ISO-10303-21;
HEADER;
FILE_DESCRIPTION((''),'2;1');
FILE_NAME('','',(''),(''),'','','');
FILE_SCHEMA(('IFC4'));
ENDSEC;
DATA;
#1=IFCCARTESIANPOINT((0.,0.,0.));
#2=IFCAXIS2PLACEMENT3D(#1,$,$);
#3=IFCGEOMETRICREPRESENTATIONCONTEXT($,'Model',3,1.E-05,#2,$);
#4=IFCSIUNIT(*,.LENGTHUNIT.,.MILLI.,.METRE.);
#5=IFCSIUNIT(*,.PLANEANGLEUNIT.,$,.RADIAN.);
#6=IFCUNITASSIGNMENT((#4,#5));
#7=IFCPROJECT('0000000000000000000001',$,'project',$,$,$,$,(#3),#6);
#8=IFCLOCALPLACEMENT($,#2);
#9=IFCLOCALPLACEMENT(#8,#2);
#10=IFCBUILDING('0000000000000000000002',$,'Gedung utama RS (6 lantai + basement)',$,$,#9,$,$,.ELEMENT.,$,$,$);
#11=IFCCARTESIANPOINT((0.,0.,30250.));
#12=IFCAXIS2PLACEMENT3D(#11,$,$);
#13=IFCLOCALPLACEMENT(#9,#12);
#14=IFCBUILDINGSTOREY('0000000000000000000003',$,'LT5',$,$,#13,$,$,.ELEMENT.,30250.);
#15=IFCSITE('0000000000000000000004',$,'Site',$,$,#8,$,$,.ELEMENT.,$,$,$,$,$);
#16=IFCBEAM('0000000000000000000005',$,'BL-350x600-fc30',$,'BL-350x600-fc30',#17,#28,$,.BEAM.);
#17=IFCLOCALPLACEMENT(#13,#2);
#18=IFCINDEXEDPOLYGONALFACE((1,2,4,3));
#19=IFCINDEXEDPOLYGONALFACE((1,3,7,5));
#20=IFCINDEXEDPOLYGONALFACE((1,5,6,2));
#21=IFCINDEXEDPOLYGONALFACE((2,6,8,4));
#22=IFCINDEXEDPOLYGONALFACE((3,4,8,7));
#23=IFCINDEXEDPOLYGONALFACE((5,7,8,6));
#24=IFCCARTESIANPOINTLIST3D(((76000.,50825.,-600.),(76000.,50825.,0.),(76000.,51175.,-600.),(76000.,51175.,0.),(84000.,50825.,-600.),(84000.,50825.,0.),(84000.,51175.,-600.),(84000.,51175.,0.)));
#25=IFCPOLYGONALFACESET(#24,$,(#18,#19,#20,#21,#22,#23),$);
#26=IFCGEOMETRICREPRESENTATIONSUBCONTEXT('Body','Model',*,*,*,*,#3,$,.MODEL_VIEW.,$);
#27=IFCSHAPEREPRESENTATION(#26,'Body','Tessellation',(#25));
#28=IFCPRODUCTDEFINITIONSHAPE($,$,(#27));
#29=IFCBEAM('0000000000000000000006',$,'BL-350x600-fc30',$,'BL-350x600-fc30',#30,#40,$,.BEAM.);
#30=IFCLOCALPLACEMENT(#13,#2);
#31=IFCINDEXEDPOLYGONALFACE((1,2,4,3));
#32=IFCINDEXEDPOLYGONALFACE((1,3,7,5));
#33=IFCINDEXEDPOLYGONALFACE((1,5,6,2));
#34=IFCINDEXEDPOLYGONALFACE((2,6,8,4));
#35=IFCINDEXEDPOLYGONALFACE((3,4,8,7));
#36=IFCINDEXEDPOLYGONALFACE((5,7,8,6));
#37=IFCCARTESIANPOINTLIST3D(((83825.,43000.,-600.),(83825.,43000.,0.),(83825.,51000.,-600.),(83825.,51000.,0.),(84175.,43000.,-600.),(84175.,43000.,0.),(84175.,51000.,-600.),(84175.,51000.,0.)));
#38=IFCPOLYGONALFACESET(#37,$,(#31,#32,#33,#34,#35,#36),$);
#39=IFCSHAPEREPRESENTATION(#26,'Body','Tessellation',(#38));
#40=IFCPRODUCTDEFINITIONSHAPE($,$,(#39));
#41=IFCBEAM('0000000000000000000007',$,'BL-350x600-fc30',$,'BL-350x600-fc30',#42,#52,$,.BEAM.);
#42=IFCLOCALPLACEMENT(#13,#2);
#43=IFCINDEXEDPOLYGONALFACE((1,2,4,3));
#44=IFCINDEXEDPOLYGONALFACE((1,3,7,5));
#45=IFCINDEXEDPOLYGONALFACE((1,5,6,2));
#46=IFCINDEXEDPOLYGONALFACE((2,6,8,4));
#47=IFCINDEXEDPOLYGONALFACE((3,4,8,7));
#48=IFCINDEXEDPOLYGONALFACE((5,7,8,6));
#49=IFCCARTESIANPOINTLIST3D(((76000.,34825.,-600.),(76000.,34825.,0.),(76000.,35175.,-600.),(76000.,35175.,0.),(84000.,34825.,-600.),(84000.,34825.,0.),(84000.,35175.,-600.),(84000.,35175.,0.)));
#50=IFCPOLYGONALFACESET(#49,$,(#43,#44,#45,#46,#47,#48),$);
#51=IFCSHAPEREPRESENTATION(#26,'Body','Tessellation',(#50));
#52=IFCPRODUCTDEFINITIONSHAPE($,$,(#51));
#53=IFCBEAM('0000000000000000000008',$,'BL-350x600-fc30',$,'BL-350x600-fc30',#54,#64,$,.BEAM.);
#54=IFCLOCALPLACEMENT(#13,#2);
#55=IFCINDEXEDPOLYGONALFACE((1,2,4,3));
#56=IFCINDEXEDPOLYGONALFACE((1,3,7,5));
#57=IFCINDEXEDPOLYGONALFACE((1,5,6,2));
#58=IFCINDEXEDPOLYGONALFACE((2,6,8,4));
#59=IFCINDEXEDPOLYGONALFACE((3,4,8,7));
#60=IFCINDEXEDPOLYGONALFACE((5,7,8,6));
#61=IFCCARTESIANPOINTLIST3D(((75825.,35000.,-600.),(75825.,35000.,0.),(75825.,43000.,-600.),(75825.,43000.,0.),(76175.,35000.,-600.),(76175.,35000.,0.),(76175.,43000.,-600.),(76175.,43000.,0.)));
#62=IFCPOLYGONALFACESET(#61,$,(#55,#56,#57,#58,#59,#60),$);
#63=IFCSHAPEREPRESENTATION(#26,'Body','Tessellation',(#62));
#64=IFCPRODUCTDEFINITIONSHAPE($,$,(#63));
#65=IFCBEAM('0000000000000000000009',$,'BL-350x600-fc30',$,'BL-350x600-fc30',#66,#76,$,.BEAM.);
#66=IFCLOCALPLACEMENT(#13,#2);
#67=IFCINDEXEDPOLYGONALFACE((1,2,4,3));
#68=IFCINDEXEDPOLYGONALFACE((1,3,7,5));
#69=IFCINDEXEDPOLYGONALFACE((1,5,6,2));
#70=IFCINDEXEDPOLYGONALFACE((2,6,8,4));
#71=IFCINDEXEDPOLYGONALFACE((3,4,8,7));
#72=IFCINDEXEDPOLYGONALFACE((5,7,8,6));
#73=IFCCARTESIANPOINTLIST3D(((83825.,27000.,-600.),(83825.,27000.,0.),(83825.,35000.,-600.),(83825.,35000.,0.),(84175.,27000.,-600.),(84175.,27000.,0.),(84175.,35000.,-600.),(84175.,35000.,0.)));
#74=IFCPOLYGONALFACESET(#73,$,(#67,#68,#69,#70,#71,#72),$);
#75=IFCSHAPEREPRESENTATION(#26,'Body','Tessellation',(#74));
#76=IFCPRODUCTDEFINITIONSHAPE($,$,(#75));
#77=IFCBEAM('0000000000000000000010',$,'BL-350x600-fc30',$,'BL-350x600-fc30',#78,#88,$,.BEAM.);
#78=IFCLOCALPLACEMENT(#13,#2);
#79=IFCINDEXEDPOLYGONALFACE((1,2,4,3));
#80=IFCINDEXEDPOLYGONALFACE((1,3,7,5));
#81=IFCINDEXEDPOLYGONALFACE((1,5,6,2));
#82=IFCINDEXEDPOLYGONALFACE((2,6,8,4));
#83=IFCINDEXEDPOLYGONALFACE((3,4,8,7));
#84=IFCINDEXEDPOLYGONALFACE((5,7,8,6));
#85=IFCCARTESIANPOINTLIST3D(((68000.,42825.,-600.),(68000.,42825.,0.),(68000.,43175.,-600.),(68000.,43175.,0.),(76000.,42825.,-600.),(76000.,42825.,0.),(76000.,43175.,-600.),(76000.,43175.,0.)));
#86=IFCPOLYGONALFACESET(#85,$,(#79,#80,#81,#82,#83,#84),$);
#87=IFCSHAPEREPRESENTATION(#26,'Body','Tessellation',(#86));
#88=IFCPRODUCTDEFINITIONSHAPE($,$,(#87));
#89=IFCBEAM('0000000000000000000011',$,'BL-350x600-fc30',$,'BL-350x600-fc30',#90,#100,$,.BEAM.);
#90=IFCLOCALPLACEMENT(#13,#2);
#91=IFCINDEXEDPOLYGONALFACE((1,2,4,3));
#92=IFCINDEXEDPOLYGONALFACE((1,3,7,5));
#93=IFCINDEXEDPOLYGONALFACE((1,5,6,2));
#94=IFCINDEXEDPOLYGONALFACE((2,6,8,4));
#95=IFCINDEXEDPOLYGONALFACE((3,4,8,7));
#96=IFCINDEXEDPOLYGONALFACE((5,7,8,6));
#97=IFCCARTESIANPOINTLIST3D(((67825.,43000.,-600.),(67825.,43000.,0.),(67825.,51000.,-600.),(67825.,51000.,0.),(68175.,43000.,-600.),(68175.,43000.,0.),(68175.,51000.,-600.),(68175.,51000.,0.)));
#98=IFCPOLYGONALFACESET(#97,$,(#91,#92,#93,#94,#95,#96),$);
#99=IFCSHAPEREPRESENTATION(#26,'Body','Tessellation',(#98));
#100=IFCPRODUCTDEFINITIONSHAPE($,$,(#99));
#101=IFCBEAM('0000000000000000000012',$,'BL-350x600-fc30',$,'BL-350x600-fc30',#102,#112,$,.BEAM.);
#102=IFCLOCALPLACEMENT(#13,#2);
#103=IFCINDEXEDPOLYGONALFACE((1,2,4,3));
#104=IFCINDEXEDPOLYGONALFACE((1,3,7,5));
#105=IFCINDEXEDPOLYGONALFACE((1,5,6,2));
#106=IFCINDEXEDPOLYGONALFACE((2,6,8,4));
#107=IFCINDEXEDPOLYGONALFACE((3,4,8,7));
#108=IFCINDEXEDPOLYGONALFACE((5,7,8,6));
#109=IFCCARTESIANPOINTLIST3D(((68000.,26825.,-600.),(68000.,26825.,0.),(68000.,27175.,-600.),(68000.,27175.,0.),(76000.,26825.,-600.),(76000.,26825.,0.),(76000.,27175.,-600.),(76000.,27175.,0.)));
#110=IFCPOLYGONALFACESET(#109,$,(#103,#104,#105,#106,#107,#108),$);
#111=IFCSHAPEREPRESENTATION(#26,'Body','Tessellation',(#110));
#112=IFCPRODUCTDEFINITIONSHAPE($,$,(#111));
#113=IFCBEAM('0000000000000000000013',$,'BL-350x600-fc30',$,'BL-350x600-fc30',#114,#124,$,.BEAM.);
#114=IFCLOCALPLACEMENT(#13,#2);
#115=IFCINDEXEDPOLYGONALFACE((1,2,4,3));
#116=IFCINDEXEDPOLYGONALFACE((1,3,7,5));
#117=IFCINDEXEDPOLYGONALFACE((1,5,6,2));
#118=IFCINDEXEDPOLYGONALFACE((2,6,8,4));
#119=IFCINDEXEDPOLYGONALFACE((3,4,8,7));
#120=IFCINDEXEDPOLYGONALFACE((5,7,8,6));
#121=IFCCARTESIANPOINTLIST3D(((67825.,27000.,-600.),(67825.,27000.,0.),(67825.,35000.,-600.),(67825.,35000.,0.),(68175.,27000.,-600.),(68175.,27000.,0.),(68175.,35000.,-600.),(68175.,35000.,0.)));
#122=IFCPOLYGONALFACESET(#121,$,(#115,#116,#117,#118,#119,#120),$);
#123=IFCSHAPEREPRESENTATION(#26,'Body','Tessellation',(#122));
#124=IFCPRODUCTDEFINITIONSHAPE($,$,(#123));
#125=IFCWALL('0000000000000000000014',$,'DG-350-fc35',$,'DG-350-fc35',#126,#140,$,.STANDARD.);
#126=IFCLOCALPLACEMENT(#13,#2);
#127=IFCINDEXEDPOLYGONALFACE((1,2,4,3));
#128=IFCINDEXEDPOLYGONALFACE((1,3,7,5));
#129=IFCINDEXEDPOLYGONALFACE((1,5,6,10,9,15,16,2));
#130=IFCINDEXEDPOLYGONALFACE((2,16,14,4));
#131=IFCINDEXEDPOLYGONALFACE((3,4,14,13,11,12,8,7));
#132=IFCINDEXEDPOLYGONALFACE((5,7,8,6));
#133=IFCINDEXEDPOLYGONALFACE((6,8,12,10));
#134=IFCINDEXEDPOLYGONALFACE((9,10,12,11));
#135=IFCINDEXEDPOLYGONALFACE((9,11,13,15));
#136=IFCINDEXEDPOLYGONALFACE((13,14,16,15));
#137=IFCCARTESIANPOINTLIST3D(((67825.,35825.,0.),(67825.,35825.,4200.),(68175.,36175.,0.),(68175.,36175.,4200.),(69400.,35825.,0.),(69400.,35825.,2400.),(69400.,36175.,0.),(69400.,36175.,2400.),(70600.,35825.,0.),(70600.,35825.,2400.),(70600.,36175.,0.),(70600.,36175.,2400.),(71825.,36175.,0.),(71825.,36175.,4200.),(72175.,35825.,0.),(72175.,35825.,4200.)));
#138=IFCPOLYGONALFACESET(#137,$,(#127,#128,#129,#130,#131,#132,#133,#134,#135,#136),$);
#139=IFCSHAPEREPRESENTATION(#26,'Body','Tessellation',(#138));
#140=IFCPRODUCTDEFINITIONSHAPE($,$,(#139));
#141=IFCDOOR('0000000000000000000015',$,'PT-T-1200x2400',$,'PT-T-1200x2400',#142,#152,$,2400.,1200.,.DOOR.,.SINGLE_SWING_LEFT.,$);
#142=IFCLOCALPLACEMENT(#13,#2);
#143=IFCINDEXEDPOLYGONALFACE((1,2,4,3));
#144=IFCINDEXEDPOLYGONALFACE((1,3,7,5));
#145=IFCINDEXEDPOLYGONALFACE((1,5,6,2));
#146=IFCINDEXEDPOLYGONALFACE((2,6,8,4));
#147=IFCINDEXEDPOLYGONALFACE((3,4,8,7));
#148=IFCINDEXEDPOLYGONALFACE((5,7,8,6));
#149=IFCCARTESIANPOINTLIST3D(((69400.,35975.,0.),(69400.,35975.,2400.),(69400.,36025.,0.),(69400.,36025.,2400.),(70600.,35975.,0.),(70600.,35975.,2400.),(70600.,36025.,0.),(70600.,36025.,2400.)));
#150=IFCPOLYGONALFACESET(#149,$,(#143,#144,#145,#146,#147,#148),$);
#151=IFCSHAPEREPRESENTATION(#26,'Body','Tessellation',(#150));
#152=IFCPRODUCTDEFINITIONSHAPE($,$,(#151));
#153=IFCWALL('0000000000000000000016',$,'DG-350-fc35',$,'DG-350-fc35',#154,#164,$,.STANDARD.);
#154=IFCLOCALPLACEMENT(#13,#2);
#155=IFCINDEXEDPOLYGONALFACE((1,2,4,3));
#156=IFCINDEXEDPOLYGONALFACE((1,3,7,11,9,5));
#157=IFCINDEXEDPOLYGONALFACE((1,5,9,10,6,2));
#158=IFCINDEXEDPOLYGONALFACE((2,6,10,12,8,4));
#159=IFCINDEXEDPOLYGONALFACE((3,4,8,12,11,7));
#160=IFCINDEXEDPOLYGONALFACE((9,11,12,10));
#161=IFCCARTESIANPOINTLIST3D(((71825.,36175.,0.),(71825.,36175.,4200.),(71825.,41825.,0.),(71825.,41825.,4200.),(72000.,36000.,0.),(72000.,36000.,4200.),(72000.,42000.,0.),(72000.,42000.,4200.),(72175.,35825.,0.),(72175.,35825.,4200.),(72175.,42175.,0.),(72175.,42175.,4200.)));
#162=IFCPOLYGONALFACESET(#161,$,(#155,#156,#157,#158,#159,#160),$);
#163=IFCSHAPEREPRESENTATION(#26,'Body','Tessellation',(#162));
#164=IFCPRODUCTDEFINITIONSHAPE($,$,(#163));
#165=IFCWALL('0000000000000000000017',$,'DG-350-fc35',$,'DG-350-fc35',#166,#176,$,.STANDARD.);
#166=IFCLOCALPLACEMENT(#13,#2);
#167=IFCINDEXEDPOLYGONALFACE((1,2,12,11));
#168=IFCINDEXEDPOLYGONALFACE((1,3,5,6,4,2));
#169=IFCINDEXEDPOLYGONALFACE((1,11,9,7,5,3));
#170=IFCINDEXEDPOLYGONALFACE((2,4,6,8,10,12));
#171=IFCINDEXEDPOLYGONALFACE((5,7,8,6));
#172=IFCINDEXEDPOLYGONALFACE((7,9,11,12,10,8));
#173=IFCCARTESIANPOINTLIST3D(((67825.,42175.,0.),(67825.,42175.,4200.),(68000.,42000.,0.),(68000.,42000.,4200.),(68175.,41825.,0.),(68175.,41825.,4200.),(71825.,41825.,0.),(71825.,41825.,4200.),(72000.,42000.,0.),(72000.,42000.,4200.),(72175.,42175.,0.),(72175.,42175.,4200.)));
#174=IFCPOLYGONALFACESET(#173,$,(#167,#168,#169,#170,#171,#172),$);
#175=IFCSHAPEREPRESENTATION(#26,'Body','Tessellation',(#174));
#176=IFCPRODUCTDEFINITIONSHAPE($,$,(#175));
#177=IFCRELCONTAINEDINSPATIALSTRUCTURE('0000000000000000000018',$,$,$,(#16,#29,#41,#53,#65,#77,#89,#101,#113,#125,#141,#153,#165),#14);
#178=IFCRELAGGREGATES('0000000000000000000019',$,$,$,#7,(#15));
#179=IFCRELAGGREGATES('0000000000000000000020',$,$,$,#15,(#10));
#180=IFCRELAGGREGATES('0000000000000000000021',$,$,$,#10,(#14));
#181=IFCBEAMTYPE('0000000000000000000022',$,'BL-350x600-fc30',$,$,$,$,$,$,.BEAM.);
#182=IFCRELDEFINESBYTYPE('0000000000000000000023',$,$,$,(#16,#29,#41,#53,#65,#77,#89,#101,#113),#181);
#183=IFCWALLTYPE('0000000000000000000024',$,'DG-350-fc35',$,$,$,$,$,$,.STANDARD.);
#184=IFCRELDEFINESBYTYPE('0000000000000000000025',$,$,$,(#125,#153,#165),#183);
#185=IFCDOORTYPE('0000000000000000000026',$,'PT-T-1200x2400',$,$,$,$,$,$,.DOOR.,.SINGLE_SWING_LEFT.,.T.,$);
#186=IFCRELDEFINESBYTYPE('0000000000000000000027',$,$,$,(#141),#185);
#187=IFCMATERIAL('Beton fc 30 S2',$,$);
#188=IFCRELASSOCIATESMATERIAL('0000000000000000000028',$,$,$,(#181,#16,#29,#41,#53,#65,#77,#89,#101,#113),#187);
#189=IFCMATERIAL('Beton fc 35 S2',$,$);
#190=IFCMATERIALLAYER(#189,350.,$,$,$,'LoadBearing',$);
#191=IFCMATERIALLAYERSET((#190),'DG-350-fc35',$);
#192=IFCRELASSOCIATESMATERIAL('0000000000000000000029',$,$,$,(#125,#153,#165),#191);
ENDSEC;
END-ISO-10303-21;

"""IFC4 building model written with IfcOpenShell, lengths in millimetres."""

from ifc_helpers import new_model, si_unit, frame, frame_2d, origin, origin_2d, place, context, subcontext, project, spatial, polyline, rectangle, outline, extrude, material, layer, layer_set, layer_usage, material_profile, profile_set, profile_usage, type_object, element, fill, save


model = new_model("IFC4")

# Units and contexts
model_context = context("Model", 3, precision=1e-05, world=origin())
body_context = subcontext(model_context, "Body", "Model", "MODEL_VIEW")
ifc_project = project(units=[si_unit("LENGTHUNIT", "METRE", prefix="MILLI"), si_unit("PLANEANGLEUNIT", "RADIAN")], contexts=[model_context])

# Site, building, storey
site_placement = place(None, origin())
site = spatial("IfcSite", under=ifc_project, at=site_placement, Name="Site", CompositionType="ELEMENT")
building_placement = place(site_placement, origin())
building = spatial("IfcBuilding", under=site, at=building_placement, Name="Gedung utama RS (6 lantai + basement)", CompositionType="ELEMENT")
storey_placement = place(building_placement, frame((0.0, 0.0, 30250.0)))
storey = spatial("IfcBuildingStorey", under=building, at=storey_placement, Name="LT5", CompositionType="ELEMENT", Elevation=30250.0)

# Beams
ifc_material_1 = material(Name="Beton fc 30 S2")
ifc_material_profile_1 = material_profile(ifc_material_1, rectangle(XDim=350.0, YDim=600.0, at=origin_2d()), Name="BL-350x600-fc30")
ifc_profile_set_1 = profile_set([ifc_material_profile_1], Name="BL-350x600-fc30")
ifc_profile_usage_1 = profile_usage(ifc_profile_set_1, cardinal=8)
beam_type = type_object("IfcBeamType", Name="BL-350x600-fc30", PredefinedType="BEAM", material=ifc_profile_set_1)
beam_1_placement = place(storey_placement, frame((76000.0, 51000.0, -300.0)))
element("IfcBeam", 1, at=beam_1_placement, inside=storey, type_object=beam_type, material=ifc_profile_usage_1, Name="BL-350x600-fc30", ObjectType="BL-350x600-fc30", PredefinedType="BEAM", context=body_context, shape_type="SweptSolid", body=[
    extrude(rectangle(XDim=350.0, YDim=600.0, at=origin_2d()), frame((0.0, 0.0, 0.0), z_axis=(1.0, 0.0, 0.0), x_axis=(0.0, 1.0, 0.0)), (0.0, 0.0, 1.0), 8000.0),
])
beam_2_placement = place(storey_placement, frame((84000.0, 43000.0, -300.0)))
element("IfcBeam", 2, at=beam_2_placement, inside=storey, type_object=beam_type, material=ifc_profile_usage_1, Name="BL-350x600-fc30", ObjectType="BL-350x600-fc30", PredefinedType="BEAM", context=body_context, shape_type="SweptSolid", body=[
    extrude(rectangle(XDim=350.0, YDim=600.0, at=origin_2d()), frame((0.0, 0.0, 0.0), z_axis=(0.0, 1.0, 0.0), x_axis=(-1.0, 0.0, 0.0)), (0.0, 0.0, 1.0), 8000.0),
])
beam_3_placement = place(storey_placement, frame((76000.0, 35000.0, -300.0)))
element("IfcBeam", 3, at=beam_3_placement, inside=storey, type_object=beam_type, material=ifc_profile_usage_1, Name="BL-350x600-fc30", ObjectType="BL-350x600-fc30", PredefinedType="BEAM", context=body_context, shape_type="SweptSolid", body=[
    extrude(rectangle(XDim=350.0, YDim=600.0, at=origin_2d()), frame((0.0, 0.0, 0.0), z_axis=(1.0, 0.0, 0.0), x_axis=(0.0, 1.0, 0.0)), (0.0, 0.0, 1.0), 8000.0),
])
for number, where, name in (
    (4, (76000.0, 35000.0, -300.0), "BL-350x600-fc30"),
    (5, (84000.0, 27000.0, -300.0), "BL-350x600-fc30"),
):
    element("IfcBeam", number, at=place(storey_placement, frame(where)), inside=storey, type_object=beam_type, material=ifc_profile_usage_1, Name=name, ObjectType="BL-350x600-fc30", PredefinedType="BEAM", context=body_context, shape_type="SweptSolid", body=[
        extrude(rectangle(XDim=350.0, YDim=600.0, at=origin_2d()), frame((0.0, 0.0, 0.0), z_axis=(0.0, 1.0, 0.0), x_axis=(-1.0, 0.0, 0.0)), (0.0, 0.0, 1.0), 8000.0),
    ])
beam_4_placement = place(storey_placement, frame((68000.0, 43000.0, -300.0)))
element("IfcBeam", 6, at=beam_4_placement, inside=storey, type_object=beam_type, material=ifc_profile_usage_1, Name="BL-350x600-fc30", ObjectType="BL-350x600-fc30", PredefinedType="BEAM", context=body_context, shape_type="SweptSolid", body=[
    extrude(rectangle(XDim=350.0, YDim=600.0, at=origin_2d()), frame((0.0, 0.0, 0.0), z_axis=(1.0, 0.0, 0.0), x_axis=(0.0, 1.0, 0.0)), (0.0, 0.0, 1.0), 8000.0),
])
beam_5_placement = place(storey_placement, frame((68000.0, 43000.0, -300.0)))
element("IfcBeam", 7, at=beam_5_placement, inside=storey, type_object=beam_type, material=ifc_profile_usage_1, Name="BL-350x600-fc30", ObjectType="BL-350x600-fc30", PredefinedType="BEAM", context=body_context, shape_type="SweptSolid", body=[
    extrude(rectangle(XDim=350.0, YDim=600.0, at=origin_2d()), frame((0.0, 0.0, 0.0), z_axis=(0.0, 1.0, 0.0), x_axis=(-1.0, 0.0, 0.0)), (0.0, 0.0, 1.0), 8000.0),
])
beam_6_placement = place(storey_placement, frame((68000.0, 27000.0, -300.0)))
element("IfcBeam", 8, at=beam_6_placement, inside=storey, type_object=beam_type, material=ifc_profile_usage_1, Name="BL-350x600-fc30", ObjectType="BL-350x600-fc30", PredefinedType="BEAM", context=body_context, shape_type="SweptSolid", body=[
    extrude(rectangle(XDim=350.0, YDim=600.0, at=origin_2d()), frame((0.0, 0.0, 0.0), z_axis=(1.0, 0.0, 0.0), x_axis=(0.0, 1.0, 0.0)), (0.0, 0.0, 1.0), 8000.0),
])
beam_7_placement = place(storey_placement, frame((68000.0, 27000.0, -300.0)))
element("IfcBeam", 9, at=beam_7_placement, inside=storey, type_object=beam_type, material=ifc_profile_usage_1, Name="BL-350x600-fc30", ObjectType="BL-350x600-fc30", PredefinedType="BEAM", context=body_context, shape_type="SweptSolid", body=[
    extrude(rectangle(XDim=350.0, YDim=600.0, at=origin_2d()), frame((0.0, 0.0, 0.0), z_axis=(0.0, 1.0, 0.0), x_axis=(-1.0, 0.0, 0.0)), (0.0, 0.0, 1.0), 8000.0),
])

# Wall, opening, door
ifc_material_2 = material(Name="Beton fc 35 S2")
ifc_layer = layer(ifc_material_2, 350.0, Category="LoadBearing")
ifc_layer_set = layer_set([ifc_layer], Name="DG-350-fc35")
ifc_layer_usage = layer_usage(ifc_layer_set, "AXIS2", "NEGATIVE", 175.0)
wall_type = type_object("IfcWallType", Name="DG-350-fc35", PredefinedType="STANDARD")
wall_1_placement = place(storey_placement, frame((68000.0, 36000.0, 0.0), z_axis=(0.0, 0.0, 1.0), x_axis=(1.0, 0.0, 0.0)))
wall_1 = element("IfcWall", 10, at=wall_1_placement, inside=storey, type_object=wall_type, material=ifc_layer_usage, Name="DG-350-fc35", ObjectType="DG-350-fc35", PredefinedType="STANDARD", context=body_context, shape_type="SweptSolid", body=[
    extrude(outline(polyline([(-175.0, -175.0), (0.0, 0.0), (175.0, 175.0), (3825.0, 175.0), (4000.0, 0.0), (4175.0, -175.0), (-175.0, -175.0)])), origin(), (0.0, 0.0, 1.0), 4200.0),
])
opening_placement = place(wall_1_placement, frame((1400.0, 0.0, 0.0), z_axis=(0.0, 0.0, 1.0), x_axis=(1.0, 0.0, 0.0)))
opening = element("IfcOpeningElement", 11, at=opening_placement, cuts=wall_1, PredefinedType="OPENING", context=body_context, shape_type="SweptSolid", body=[
    extrude(rectangle(XDim=1200.0, YDim=370.0, at=frame_2d((600.0, 0.0))), origin(), (0.0, 0.0, 1.0), 2400.0),
])
door_type = type_object("IfcDoorType", Name="PT-T-1200x2400", OperationType="SINGLE_SWING_LEFT", ParameterTakesPrecedence=True, PredefinedType="DOOR")
door_placement = place(opening_placement, origin())
door = element("IfcDoor", 12, at=door_placement, inside=storey, type_object=door_type, Name="PT-T-1200x2400", ObjectType="PT-T-1200x2400", OperationType="SINGLE_SWING_LEFT", OverallHeight=2400.0, OverallWidth=1200.0, PredefinedType="DOOR", context=body_context, shape_type="SweptSolid", body=[
    extrude(rectangle(XDim=1200.0, YDim=50.0, at=frame_2d((600.0, 0.0))), origin(), (0.0, 0.0, 1.0), 2400.0),
])
fill(opening, door)

# Walls
wall_2_placement = place(storey_placement, frame((72000.0, 36000.0, 0.0), z_axis=(0.0, 0.0, 1.0), x_axis=(0.0, 1.0, 0.0)))
element("IfcWall", 13, at=wall_2_placement, inside=storey, type_object=wall_type, material=ifc_layer_usage, Name="DG-350-fc35", ObjectType="DG-350-fc35", PredefinedType="STANDARD", context=body_context, shape_type="SweptSolid", body=[
    extrude(outline(polyline([(-175.0, -175.0), (0.0, 0.0), (175.0, 175.0), (5825.0, 175.0), (6000.0, 0.0), (6175.0, -175.0), (-175.0, -175.0)])), origin(), (0.0, 0.0, 1.0), 4200.0),
])
wall_3_placement = place(storey_placement, frame((72000.0, 42000.0, 0.0), z_axis=(0.0, 0.0, 1.0), x_axis=(-1.0, 0.0, 0.0)))
element("IfcWall", 14, at=wall_3_placement, inside=storey, type_object=wall_type, material=ifc_layer_usage, Name="DG-350-fc35", ObjectType="DG-350-fc35", PredefinedType="STANDARD", context=body_context, shape_type="SweptSolid", body=[
    extrude(outline(polyline([(-175.0, -175.0), (0.0, 0.0), (175.0, 175.0), (3825.0, 175.0), (4000.0, 0.0), (4175.0, -175.0), (-175.0, -175.0)])), origin(), (0.0, 0.0, 1.0), 4200.0),
])

save(model, "model.ifc")
